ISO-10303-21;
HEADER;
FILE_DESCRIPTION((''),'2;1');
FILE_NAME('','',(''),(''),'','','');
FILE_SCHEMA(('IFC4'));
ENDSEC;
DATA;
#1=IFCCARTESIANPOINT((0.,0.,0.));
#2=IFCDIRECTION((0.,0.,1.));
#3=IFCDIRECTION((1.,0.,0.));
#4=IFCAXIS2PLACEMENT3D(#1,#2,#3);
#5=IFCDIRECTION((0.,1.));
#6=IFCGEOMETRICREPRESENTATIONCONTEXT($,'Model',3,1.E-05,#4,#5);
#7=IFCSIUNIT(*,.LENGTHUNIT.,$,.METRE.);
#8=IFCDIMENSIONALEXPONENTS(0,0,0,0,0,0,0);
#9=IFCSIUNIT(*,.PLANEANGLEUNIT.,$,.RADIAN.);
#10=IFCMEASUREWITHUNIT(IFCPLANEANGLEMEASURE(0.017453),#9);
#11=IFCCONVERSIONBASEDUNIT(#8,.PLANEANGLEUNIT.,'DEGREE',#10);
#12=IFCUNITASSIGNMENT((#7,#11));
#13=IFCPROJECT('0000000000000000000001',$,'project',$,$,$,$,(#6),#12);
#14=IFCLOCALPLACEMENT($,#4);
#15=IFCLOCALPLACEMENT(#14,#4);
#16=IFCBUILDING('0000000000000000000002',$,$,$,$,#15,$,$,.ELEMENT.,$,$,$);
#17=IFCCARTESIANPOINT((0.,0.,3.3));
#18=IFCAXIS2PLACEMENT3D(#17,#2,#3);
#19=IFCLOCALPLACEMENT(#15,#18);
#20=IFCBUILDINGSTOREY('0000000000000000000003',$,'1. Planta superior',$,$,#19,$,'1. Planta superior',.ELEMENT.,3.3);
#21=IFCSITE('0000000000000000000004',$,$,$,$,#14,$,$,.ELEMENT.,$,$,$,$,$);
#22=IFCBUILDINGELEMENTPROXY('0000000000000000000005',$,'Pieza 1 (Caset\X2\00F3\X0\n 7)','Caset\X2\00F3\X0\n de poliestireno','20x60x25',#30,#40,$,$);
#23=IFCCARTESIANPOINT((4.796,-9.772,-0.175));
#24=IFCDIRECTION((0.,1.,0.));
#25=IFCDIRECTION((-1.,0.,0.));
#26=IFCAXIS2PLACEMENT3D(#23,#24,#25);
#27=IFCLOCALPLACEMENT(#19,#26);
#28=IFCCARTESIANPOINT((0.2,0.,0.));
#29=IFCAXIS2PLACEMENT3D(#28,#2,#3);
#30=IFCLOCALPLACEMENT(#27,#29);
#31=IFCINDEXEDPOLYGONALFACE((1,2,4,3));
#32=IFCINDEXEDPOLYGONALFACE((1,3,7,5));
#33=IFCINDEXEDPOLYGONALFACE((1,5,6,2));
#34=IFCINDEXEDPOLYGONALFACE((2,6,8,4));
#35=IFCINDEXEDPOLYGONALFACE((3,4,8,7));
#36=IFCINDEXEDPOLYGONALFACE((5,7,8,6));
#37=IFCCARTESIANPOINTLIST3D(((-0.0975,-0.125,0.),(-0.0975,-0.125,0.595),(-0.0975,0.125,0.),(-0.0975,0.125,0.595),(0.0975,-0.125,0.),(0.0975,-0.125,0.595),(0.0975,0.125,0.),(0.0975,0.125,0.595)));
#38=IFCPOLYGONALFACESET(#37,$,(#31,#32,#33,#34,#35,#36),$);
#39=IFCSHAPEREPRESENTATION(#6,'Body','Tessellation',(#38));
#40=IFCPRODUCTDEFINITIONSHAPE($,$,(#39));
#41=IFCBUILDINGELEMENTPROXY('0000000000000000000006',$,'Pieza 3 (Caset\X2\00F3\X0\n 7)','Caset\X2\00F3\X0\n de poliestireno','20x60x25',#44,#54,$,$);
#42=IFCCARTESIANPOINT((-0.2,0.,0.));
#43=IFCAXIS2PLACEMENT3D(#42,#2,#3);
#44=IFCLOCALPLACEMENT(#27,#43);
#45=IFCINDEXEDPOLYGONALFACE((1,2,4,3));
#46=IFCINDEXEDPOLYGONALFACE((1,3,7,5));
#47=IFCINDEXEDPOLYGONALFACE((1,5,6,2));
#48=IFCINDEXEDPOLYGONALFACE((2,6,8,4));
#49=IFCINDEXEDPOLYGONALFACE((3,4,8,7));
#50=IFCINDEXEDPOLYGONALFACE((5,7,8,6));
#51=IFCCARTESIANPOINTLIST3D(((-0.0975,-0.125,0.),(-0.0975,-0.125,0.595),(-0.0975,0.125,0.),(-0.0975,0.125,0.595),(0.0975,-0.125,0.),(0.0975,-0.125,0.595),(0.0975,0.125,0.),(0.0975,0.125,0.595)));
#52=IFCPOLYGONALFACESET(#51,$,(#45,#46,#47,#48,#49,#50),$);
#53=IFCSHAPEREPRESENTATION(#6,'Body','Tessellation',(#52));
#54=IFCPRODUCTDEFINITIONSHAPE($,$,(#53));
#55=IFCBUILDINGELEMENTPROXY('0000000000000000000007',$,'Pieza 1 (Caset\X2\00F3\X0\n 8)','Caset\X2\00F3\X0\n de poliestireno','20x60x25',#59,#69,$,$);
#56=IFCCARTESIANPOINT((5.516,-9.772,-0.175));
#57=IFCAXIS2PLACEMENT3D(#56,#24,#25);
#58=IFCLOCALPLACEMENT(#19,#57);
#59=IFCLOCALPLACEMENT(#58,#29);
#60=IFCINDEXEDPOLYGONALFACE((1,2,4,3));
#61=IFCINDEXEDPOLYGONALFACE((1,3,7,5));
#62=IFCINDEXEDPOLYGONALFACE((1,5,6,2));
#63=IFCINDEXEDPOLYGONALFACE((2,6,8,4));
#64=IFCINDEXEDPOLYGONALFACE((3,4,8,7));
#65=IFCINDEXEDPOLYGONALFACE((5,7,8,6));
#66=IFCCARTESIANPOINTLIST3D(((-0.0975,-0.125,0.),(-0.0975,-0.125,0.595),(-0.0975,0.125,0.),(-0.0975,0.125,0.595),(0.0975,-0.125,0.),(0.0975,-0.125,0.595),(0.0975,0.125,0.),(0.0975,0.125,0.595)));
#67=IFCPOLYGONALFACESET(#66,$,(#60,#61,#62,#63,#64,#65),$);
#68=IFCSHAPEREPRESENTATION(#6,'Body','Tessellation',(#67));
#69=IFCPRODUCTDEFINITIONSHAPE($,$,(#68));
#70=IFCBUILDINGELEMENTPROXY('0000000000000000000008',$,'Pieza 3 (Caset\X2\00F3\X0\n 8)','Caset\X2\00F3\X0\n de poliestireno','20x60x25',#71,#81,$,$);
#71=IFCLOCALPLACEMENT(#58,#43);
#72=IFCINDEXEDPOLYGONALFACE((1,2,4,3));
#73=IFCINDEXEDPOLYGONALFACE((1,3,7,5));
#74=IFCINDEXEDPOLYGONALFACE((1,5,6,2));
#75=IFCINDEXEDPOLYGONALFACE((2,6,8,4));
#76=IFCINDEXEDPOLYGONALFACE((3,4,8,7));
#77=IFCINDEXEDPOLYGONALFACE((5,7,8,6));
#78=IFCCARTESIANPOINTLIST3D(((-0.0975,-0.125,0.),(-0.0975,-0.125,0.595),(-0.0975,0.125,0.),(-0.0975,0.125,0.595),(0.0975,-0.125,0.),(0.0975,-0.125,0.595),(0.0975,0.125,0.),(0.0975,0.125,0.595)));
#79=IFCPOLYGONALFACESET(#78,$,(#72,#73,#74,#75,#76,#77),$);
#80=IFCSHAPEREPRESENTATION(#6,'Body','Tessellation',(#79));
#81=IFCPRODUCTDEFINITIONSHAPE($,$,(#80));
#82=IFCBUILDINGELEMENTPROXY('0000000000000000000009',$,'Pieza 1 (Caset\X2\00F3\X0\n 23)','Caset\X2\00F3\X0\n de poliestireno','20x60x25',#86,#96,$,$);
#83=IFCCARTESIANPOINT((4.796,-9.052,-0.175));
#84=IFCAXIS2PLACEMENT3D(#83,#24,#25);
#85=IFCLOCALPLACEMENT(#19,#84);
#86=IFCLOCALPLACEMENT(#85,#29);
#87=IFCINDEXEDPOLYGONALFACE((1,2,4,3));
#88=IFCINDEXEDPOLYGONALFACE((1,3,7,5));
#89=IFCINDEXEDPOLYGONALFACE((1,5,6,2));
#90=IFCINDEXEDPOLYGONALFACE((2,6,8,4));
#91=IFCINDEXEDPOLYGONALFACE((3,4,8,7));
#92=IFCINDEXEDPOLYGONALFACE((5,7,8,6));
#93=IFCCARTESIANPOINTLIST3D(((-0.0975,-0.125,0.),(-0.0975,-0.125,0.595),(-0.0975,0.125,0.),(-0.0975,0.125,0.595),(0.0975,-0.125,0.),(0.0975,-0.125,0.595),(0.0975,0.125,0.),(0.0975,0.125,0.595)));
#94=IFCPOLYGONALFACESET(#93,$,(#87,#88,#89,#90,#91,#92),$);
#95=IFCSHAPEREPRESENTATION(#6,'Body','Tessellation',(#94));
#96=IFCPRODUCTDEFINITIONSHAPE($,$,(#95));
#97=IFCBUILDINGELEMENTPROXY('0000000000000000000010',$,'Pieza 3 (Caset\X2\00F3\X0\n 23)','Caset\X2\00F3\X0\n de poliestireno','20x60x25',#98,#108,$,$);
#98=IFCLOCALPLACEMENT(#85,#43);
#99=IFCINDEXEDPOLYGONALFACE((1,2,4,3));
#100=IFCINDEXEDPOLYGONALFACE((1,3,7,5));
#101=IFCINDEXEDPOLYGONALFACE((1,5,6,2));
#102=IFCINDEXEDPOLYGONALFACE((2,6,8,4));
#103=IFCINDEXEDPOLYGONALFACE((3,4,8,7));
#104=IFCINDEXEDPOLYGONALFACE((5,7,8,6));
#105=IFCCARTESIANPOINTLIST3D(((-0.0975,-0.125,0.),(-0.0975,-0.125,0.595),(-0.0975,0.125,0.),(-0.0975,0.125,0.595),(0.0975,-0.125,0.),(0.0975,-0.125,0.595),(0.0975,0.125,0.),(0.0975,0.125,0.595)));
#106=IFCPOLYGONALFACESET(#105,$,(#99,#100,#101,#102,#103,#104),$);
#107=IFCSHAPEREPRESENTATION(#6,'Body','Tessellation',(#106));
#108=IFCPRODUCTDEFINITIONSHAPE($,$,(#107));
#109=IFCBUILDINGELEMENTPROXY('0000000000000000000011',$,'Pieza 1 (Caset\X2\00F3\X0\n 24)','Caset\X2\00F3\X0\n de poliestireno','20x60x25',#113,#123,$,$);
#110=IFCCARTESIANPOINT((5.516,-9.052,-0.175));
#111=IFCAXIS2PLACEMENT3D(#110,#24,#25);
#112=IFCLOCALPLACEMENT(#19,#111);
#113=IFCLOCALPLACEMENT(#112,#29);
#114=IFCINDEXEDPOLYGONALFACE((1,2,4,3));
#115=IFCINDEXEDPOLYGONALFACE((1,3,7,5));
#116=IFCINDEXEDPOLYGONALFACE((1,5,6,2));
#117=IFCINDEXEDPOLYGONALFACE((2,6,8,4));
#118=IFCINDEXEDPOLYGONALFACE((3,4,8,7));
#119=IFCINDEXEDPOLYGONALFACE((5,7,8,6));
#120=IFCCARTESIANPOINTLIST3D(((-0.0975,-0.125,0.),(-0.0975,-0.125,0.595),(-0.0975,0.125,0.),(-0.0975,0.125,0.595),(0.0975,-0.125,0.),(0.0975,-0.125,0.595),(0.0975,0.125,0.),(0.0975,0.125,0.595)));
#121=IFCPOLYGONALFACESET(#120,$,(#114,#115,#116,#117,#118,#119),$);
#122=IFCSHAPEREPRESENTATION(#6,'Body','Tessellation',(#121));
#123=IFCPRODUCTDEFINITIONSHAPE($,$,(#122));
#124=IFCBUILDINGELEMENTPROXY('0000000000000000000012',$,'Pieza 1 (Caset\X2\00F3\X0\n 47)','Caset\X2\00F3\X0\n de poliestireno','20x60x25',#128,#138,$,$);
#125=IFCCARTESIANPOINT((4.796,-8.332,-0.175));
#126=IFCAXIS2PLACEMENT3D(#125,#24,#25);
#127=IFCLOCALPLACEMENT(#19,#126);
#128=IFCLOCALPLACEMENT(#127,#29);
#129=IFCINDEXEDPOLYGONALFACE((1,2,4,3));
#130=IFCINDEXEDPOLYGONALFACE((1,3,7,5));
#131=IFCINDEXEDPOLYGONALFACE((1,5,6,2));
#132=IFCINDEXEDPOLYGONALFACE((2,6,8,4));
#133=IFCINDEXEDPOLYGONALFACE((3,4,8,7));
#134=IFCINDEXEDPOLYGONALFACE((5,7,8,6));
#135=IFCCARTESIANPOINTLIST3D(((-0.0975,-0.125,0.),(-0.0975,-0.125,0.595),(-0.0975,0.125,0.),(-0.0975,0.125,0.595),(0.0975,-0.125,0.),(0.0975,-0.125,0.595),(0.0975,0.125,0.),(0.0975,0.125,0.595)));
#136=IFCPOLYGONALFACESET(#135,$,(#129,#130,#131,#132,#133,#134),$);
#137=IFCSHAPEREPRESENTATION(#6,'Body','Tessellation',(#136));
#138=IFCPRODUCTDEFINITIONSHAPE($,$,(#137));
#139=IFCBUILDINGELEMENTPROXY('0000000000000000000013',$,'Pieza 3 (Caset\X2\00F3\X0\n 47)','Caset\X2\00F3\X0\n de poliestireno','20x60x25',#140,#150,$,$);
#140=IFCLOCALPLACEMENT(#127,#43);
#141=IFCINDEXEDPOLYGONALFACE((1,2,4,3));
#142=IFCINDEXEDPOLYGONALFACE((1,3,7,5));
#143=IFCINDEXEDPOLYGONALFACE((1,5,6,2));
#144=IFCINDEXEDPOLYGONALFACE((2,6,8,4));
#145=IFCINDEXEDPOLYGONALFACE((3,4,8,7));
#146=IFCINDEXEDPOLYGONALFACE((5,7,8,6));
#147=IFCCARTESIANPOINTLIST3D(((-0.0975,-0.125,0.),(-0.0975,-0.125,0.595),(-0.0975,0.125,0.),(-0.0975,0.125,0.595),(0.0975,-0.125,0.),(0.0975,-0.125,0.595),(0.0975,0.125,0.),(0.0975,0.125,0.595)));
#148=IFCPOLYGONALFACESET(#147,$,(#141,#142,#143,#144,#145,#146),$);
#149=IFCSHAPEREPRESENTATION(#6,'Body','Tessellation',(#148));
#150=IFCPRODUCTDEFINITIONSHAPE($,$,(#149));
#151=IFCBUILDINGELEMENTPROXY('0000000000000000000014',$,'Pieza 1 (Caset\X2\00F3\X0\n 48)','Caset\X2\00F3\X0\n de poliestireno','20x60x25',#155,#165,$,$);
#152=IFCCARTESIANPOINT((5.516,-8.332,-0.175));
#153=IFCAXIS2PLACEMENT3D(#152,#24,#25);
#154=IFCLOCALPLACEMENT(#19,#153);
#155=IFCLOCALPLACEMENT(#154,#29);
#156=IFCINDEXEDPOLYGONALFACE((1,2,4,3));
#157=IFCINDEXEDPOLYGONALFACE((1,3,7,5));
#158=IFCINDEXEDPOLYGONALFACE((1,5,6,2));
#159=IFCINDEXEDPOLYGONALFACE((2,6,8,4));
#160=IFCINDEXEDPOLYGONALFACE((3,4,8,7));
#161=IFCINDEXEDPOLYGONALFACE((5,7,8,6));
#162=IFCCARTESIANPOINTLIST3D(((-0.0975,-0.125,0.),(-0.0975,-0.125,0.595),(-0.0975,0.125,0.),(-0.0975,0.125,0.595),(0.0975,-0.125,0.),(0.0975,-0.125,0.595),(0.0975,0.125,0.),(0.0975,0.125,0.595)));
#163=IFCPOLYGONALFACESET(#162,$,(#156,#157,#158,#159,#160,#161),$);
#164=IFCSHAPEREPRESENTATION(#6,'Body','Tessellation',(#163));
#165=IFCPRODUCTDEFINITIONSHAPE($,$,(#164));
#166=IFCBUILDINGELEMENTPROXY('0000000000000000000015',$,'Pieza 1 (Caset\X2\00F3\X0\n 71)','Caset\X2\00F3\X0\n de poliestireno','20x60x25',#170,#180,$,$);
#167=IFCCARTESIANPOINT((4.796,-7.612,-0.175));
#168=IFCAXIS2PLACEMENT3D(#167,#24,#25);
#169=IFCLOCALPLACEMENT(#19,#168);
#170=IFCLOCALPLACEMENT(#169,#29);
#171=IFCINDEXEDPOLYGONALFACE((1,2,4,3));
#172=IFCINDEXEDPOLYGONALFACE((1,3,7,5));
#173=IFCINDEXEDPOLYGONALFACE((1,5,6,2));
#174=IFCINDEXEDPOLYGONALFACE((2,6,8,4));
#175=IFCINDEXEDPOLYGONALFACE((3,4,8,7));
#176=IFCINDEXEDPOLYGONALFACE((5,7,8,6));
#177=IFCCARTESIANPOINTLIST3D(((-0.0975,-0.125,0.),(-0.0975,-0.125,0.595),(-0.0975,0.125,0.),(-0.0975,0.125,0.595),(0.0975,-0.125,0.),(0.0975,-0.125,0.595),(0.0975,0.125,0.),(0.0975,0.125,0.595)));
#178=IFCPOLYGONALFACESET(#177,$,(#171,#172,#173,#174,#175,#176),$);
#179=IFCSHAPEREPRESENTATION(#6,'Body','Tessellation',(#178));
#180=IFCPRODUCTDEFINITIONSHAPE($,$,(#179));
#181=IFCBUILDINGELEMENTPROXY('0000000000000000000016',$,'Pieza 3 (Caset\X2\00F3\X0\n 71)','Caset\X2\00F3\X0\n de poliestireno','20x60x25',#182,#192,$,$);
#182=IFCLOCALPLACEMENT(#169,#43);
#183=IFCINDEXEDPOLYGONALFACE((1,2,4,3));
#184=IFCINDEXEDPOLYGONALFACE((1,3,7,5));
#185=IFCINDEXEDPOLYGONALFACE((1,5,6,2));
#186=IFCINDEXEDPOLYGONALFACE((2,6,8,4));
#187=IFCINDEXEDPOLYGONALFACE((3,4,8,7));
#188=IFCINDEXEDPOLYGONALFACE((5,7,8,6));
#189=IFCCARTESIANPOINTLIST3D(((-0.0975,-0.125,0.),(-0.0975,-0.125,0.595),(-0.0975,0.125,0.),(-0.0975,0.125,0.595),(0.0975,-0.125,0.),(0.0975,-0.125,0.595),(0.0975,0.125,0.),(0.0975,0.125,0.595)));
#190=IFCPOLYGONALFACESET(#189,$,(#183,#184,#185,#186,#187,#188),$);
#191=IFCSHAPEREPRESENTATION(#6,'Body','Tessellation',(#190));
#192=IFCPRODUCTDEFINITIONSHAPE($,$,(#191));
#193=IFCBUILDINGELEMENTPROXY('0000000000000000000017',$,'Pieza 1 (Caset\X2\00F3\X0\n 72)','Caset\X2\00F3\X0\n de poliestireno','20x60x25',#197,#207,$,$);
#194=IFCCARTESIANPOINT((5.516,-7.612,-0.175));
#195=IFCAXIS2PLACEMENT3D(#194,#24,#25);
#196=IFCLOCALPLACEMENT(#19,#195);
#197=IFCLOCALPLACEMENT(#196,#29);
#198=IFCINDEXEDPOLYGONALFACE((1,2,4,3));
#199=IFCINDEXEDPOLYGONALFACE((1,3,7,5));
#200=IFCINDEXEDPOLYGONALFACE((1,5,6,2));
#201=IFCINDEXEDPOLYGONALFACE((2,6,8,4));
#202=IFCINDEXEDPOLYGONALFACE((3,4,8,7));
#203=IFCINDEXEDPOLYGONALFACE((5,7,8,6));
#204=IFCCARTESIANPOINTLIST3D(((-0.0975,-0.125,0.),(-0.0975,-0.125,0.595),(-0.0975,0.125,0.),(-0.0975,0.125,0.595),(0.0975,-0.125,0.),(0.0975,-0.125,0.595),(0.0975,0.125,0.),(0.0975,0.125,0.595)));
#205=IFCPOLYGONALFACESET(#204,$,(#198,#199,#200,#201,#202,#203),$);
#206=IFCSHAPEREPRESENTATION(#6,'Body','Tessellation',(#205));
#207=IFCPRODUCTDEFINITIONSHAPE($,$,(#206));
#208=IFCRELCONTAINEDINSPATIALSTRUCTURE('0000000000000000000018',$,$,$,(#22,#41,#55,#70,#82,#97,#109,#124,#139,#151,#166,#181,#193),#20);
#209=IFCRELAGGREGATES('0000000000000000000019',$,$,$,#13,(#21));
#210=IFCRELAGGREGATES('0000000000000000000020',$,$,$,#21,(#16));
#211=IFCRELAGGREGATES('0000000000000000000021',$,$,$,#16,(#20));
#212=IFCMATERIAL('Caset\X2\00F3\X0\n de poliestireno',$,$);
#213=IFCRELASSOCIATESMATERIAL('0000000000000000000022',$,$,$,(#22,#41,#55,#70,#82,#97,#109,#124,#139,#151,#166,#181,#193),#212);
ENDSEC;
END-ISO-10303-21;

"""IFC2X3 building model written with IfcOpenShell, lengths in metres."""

from ifc_helpers import new_model, entity, si_unit, converted_unit, direction, frame, origin_with_axes, origin_2d_with_axis, place, context, project, spatial, rectangle, extrude, source, transform, mapped, material, element, save


model = new_model("IFC2X3")

# Units and contexts
model_context = context("Model", 3, precision=1e-05, world=origin_with_axes(), true_north=direction((0.0, 1.0)))
ifc_project = project(units=[si_unit("LENGTHUNIT", "METRE"), converted_unit("PLANEANGLEUNIT", "DEGREE", entity("IfcPlaneAngleMeasure", 0.017453), si_unit("PLANEANGLEUNIT", "RADIAN"), dimensions=[0, 0, 0, 0, 0, 0, 0])], contexts=[model_context])

# Site, building, storey
site_placement = place(None, origin_with_axes())
site = spatial("IfcSite", under=ifc_project, at=site_placement, CompositionType="ELEMENT")
building_placement = place(site_placement, origin_with_axes())
building = spatial("IfcBuilding", under=site, at=building_placement, CompositionType="ELEMENT")
storey_placement = place(building_placement, frame((0.0, 0.0, 3.3), z_axis=(0.0, 0.0, 1.0), x_axis=(1.0, 0.0, 0.0)))
storey = spatial("IfcBuildingStorey", under=building, at=storey_placement, Name="1. Planta superior", LongName="1. Planta superior", CompositionType="ELEMENT", Elevation=3.3)

# Building element proxies
ifc_material = material(Name="Casetón de poliestireno")
shared_shape = source(origin_with_axes(), model_context, "Body", "SweptSolid", [
    extrude(rectangle(XDim=0.195, YDim=0.25, at=origin_2d_with_axis()), origin_with_axes(), (0.0, 0.0, 1.0), 0.595),
])
placement_1 = place(storey_placement, frame((4.796, -9.772, -0.175), z_axis=(0.0, 1.0, 0.0), x_axis=(-1.0, 0.0, 0.0)))
for number, where, z_axis, x_axis, name in (
    (1, (0.2, 0.0, 0.0), (0.0, 0.0, 1.0), (1.0, 0.0, 0.0), "Pieza 1 (Casetón 7)"),
    (2, (-0.2, 0.0, 0.0), (0.0, 0.0, 1.0), (1.0, 0.0, 0.0), "Pieza 3 (Casetón 7)"),
):
    element("IfcBuildingElementProxy", number, at=place(placement_1, frame(where, z_axis=z_axis, x_axis=x_axis)), inside=storey, material=ifc_material, Name=name, Description="Casetón de poliestireno", ObjectType="20x60x25", context=model_context, shape_type="MappedRepresentation", body=[
        mapped(shared_shape, transform((0.0, 0.0, 0.0), x_axis=(1.0, 0.0, 0.0), y_axis=(0.0, 1.0, 0.0), z_axis=(0.0, 0.0, 1.0))),
    ])
placement_2 = place(storey_placement, frame((5.516, -9.772, -0.175), z_axis=(0.0, 1.0, 0.0), x_axis=(-1.0, 0.0, 0.0)))
for number, where, z_axis, x_axis, name in (
    (3, (0.2, 0.0, 0.0), (0.0, 0.0, 1.0), (1.0, 0.0, 0.0), "Pieza 1 (Casetón 8)"),
    (4, (-0.2, 0.0, 0.0), (0.0, 0.0, 1.0), (1.0, 0.0, 0.0), "Pieza 3 (Casetón 8)"),
):
    element("IfcBuildingElementProxy", number, at=place(placement_2, frame(where, z_axis=z_axis, x_axis=x_axis)), inside=storey, material=ifc_material, Name=name, Description="Casetón de poliestireno", ObjectType="20x60x25", context=model_context, shape_type="MappedRepresentation", body=[
        mapped(shared_shape, transform((0.0, 0.0, 0.0), x_axis=(1.0, 0.0, 0.0), y_axis=(0.0, 1.0, 0.0), z_axis=(0.0, 0.0, 1.0))),
    ])
placement_3 = place(storey_placement, frame((4.796, -9.052, -0.175), z_axis=(0.0, 1.0, 0.0), x_axis=(-1.0, 0.0, 0.0)))
for number, where, z_axis, x_axis, name in (
    (5, (0.2, 0.0, 0.0), (0.0, 0.0, 1.0), (1.0, 0.0, 0.0), "Pieza 1 (Casetón 23)"),
    (6, (-0.2, 0.0, 0.0), (0.0, 0.0, 1.0), (1.0, 0.0, 0.0), "Pieza 3 (Casetón 23)"),
):
    element("IfcBuildingElementProxy", number, at=place(placement_3, frame(where, z_axis=z_axis, x_axis=x_axis)), inside=storey, material=ifc_material, Name=name, Description="Casetón de poliestireno", ObjectType="20x60x25", context=model_context, shape_type="MappedRepresentation", body=[
        mapped(shared_shape, transform((0.0, 0.0, 0.0), x_axis=(1.0, 0.0, 0.0), y_axis=(0.0, 1.0, 0.0), z_axis=(0.0, 0.0, 1.0))),
    ])
placement_4 = place(storey_placement, frame((5.516, -9.052, -0.175), z_axis=(0.0, 1.0, 0.0), x_axis=(-1.0, 0.0, 0.0)))
for number, where, z_axis, x_axis, name in (
    (7, (0.2, 0.0, 0.0), (0.0, 0.0, 1.0), (1.0, 0.0, 0.0), "Pieza 1 (Casetón 24)"),
):
    element("IfcBuildingElementProxy", number, at=place(placement_4, frame(where, z_axis=z_axis, x_axis=x_axis)), inside=storey, material=ifc_material, Name=name, Description="Casetón de poliestireno", ObjectType="20x60x25", context=model_context, shape_type="MappedRepresentation", body=[
        mapped(shared_shape, transform((0.0, 0.0, 0.0), x_axis=(1.0, 0.0, 0.0), y_axis=(0.0, 1.0, 0.0), z_axis=(0.0, 0.0, 1.0))),
    ])
placement_5 = place(storey_placement, frame((4.796, -8.332, -0.175), z_axis=(0.0, 1.0, 0.0), x_axis=(-1.0, 0.0, 0.0)))
for number, where, z_axis, x_axis, name in (
    (8, (0.2, 0.0, 0.0), (0.0, 0.0, 1.0), (1.0, 0.0, 0.0), "Pieza 1 (Casetón 47)"),
    (9, (-0.2, 0.0, 0.0), (0.0, 0.0, 1.0), (1.0, 0.0, 0.0), "Pieza 3 (Casetón 47)"),
):
    element("IfcBuildingElementProxy", number, at=place(placement_5, frame(where, z_axis=z_axis, x_axis=x_axis)), inside=storey, material=ifc_material, Name=name, Description="Casetón de poliestireno", ObjectType="20x60x25", context=model_context, shape_type="MappedRepresentation", body=[
        mapped(shared_shape, transform((0.0, 0.0, 0.0), x_axis=(1.0, 0.0, 0.0), y_axis=(0.0, 1.0, 0.0), z_axis=(0.0, 0.0, 1.0))),
    ])
placement_6 = place(storey_placement, frame((5.516, -8.332, -0.175), z_axis=(0.0, 1.0, 0.0), x_axis=(-1.0, 0.0, 0.0)))
for number, where, z_axis, x_axis, name in (
    (10, (0.2, 0.0, 0.0), (0.0, 0.0, 1.0), (1.0, 0.0, 0.0), "Pieza 1 (Casetón 48)"),
):
    element("IfcBuildingElementProxy", number, at=place(placement_6, frame(where, z_axis=z_axis, x_axis=x_axis)), inside=storey, material=ifc_material, Name=name, Description="Casetón de poliestireno", ObjectType="20x60x25", context=model_context, shape_type="MappedRepresentation", body=[
        mapped(shared_shape, transform((0.0, 0.0, 0.0), x_axis=(1.0, 0.0, 0.0), y_axis=(0.0, 1.0, 0.0), z_axis=(0.0, 0.0, 1.0))),
    ])
placement_7 = place(storey_placement, frame((4.796, -7.612, -0.175), z_axis=(0.0, 1.0, 0.0), x_axis=(-1.0, 0.0, 0.0)))
for number, where, z_axis, x_axis, name in (
    (11, (0.2, 0.0, 0.0), (0.0, 0.0, 1.0), (1.0, 0.0, 0.0), "Pieza 1 (Casetón 71)"),
    (12, (-0.2, 0.0, 0.0), (0.0, 0.0, 1.0), (1.0, 0.0, 0.0), "Pieza 3 (Casetón 71)"),
):
    element("IfcBuildingElementProxy", number, at=place(placement_7, frame(where, z_axis=z_axis, x_axis=x_axis)), inside=storey, material=ifc_material, Name=name, Description="Casetón de poliestireno", ObjectType="20x60x25", context=model_context, shape_type="MappedRepresentation", body=[
        mapped(shared_shape, transform((0.0, 0.0, 0.0), x_axis=(1.0, 0.0, 0.0), y_axis=(0.0, 1.0, 0.0), z_axis=(0.0, 0.0, 1.0))),
    ])
placement_8 = place(storey_placement, frame((5.516, -7.612, -0.175), z_axis=(0.0, 1.0, 0.0), x_axis=(-1.0, 0.0, 0.0)))
for number, where, z_axis, x_axis, name in (
    (13, (0.2, 0.0, 0.0), (0.0, 0.0, 1.0), (1.0, 0.0, 0.0), "Pieza 1 (Casetón 72)"),
):
    element("IfcBuildingElementProxy", number, at=place(placement_8, frame(where, z_axis=z_axis, x_axis=x_axis)), inside=storey, material=ifc_material, Name=name, Description="Casetón de poliestireno", ObjectType="20x60x25", context=model_context, shape_type="MappedRepresentation", body=[
        mapped(shared_shape, transform((0.0, 0.0, 0.0), x_axis=(1.0, 0.0, 0.0), y_axis=(0.0, 1.0, 0.0), z_axis=(0.0, 0.0, 1.0))),
    ])

save(model, "model.ifc")
